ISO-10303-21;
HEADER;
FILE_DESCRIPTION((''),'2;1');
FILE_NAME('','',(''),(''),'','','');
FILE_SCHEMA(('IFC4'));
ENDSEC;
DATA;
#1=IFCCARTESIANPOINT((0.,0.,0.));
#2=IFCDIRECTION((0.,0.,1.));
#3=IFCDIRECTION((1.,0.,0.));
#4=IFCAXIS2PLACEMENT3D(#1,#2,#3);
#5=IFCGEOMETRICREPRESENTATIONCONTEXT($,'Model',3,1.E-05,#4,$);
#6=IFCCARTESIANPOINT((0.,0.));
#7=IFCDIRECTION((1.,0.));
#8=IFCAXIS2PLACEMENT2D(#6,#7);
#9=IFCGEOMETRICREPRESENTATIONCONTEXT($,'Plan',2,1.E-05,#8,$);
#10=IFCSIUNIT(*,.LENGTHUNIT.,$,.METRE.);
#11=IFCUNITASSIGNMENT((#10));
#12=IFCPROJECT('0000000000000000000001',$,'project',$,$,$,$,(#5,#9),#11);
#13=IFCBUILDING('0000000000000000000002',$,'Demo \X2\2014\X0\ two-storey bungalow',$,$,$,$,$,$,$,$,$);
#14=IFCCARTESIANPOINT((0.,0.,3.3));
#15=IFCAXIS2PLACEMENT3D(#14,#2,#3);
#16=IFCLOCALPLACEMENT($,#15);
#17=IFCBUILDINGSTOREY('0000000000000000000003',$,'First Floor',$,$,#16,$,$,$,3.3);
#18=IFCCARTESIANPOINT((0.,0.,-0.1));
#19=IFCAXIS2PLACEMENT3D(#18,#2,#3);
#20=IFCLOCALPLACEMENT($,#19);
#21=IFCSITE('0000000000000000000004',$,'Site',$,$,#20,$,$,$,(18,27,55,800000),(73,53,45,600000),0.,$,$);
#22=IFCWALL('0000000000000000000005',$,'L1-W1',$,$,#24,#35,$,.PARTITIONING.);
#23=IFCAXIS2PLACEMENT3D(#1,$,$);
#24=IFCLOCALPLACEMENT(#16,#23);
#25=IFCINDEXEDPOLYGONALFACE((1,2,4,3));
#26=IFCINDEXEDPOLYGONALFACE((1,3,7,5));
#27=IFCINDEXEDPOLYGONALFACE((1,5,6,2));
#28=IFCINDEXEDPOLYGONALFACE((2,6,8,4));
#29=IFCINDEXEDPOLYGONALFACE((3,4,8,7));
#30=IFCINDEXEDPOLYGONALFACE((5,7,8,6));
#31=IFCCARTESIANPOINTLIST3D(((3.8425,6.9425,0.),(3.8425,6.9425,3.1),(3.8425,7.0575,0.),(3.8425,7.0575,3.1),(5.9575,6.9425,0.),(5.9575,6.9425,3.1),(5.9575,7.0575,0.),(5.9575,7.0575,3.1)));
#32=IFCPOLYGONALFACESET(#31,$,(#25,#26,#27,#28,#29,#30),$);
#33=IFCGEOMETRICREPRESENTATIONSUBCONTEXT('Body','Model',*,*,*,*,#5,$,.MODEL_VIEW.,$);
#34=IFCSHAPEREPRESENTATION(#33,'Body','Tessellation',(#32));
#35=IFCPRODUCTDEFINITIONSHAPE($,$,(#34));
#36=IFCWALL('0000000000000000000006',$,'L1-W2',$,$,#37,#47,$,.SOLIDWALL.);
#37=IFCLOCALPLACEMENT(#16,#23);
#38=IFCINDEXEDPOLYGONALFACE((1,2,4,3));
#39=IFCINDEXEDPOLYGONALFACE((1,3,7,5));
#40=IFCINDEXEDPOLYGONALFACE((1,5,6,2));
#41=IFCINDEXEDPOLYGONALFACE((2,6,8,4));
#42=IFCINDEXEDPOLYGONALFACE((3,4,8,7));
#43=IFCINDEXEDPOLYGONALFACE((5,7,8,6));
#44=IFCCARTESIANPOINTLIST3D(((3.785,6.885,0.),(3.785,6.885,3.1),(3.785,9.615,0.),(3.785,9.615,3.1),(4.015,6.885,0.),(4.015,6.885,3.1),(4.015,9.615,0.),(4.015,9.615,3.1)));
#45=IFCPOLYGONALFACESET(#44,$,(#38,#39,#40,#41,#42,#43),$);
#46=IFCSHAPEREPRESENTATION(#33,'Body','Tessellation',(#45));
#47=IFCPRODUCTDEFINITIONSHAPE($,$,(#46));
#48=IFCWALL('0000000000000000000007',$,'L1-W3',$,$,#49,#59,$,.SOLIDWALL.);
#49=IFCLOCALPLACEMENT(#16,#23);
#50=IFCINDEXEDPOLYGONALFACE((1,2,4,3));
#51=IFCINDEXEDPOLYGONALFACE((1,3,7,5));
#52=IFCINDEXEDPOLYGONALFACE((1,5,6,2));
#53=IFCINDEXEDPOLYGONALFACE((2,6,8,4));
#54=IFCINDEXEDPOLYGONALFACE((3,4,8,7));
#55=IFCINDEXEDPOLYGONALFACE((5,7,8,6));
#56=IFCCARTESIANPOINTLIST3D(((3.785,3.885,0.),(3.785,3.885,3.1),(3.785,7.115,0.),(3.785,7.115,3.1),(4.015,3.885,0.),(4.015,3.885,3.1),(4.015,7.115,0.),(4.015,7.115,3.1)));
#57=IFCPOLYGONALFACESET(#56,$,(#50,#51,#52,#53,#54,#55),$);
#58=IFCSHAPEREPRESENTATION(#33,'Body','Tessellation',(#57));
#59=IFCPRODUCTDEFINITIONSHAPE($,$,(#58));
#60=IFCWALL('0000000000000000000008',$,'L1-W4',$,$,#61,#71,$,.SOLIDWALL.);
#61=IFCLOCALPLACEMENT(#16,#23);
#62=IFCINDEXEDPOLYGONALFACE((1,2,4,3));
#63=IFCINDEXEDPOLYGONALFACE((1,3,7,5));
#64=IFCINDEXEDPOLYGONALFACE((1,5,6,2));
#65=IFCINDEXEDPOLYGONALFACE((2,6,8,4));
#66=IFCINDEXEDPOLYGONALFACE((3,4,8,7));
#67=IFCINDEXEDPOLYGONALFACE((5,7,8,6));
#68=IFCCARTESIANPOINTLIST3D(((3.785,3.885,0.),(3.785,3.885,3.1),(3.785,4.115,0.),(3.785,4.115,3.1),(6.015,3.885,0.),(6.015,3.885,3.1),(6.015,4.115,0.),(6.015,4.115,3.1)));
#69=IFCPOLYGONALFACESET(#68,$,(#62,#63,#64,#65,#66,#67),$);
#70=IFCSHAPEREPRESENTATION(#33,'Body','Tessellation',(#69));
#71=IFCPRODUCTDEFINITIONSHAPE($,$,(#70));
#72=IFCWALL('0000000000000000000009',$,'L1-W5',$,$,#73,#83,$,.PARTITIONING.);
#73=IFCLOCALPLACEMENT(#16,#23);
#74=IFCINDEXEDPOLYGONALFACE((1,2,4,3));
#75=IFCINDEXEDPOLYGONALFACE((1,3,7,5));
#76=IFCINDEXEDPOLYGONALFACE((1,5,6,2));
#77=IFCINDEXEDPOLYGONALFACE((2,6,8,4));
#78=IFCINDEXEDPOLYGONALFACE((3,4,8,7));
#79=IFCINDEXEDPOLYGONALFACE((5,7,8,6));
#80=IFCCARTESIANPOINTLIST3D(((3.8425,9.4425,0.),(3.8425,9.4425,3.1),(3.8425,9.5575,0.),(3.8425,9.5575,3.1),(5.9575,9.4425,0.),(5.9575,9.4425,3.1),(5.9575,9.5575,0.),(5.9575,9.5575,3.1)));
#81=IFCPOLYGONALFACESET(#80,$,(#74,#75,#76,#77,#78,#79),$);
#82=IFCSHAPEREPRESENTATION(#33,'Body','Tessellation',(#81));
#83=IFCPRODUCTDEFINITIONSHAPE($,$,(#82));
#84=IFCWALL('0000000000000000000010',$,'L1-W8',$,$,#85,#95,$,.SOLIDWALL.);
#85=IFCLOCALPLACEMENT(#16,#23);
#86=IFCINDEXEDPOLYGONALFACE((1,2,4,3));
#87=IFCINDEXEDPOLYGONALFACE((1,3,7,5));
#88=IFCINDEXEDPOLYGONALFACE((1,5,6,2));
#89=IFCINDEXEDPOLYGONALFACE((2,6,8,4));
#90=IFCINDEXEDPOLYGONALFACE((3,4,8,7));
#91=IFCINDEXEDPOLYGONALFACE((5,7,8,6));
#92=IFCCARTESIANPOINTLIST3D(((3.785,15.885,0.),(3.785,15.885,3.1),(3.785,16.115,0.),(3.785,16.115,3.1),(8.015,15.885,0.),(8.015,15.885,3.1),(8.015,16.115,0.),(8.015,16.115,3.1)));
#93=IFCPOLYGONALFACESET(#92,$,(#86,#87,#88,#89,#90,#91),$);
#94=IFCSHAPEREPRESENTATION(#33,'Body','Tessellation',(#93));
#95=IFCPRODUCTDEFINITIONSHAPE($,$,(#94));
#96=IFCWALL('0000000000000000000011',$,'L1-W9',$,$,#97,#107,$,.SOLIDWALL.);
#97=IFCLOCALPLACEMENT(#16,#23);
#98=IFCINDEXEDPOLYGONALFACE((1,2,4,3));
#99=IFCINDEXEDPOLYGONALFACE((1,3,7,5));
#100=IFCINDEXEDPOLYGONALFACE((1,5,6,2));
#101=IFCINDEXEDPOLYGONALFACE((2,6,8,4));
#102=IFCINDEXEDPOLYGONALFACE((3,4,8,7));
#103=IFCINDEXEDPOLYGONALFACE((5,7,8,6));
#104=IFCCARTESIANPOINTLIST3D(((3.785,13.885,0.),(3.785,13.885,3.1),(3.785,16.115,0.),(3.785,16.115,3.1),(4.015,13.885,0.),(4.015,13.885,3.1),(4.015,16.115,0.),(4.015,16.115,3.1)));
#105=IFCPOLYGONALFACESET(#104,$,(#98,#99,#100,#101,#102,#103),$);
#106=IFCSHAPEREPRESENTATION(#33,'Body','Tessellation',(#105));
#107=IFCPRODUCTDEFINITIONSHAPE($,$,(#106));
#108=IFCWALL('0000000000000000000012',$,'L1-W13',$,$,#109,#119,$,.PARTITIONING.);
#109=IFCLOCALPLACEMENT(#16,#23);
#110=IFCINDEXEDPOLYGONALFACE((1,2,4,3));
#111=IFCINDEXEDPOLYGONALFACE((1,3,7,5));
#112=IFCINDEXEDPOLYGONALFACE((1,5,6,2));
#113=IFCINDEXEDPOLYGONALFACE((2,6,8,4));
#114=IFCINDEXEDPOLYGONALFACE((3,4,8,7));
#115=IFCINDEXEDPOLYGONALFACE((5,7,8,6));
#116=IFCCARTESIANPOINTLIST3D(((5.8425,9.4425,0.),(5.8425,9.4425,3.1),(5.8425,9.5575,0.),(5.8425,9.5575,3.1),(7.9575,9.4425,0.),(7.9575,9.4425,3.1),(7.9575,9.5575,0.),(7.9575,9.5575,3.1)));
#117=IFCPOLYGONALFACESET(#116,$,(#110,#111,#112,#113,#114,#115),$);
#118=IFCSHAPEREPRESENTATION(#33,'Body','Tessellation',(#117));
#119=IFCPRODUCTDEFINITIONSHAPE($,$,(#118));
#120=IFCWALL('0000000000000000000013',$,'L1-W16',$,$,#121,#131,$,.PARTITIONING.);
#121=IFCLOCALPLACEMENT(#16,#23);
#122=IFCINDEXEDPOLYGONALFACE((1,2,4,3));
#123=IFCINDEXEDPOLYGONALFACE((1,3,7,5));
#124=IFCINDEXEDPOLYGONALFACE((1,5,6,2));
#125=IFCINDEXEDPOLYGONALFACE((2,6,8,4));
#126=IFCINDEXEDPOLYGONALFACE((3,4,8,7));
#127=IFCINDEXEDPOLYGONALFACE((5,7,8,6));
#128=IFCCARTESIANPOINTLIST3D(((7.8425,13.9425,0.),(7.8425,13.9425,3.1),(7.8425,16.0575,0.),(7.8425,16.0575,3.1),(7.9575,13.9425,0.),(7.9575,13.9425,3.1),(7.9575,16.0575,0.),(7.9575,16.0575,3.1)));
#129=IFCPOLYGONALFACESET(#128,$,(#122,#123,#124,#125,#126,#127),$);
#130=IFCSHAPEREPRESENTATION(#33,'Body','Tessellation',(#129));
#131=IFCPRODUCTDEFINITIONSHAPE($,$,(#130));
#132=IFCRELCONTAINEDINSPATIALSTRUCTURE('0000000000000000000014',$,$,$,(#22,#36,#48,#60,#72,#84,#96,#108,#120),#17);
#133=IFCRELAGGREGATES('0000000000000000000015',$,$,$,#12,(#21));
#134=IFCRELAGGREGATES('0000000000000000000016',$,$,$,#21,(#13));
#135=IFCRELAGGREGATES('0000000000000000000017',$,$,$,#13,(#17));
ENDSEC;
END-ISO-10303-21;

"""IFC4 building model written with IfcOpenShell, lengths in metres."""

from ifc_helpers import new_model, si_unit, frame, origin_with_axes, origin_2d_with_axis, place, context, subcontext, project, spatial, line, indexed_curve, outline, extrude, element, save


model = new_model("IFC4")

# Units and contexts
model_context = context("Model", 3, precision=1e-05, world=origin_with_axes())
plan_context = context("Plan", 2, precision=1e-05, world=origin_2d_with_axis())
body_context = subcontext(model_context, "Body", "Model", "MODEL_VIEW")
ifc_project = project(units=[si_unit("LENGTHUNIT", "METRE")], contexts=[model_context, plan_context])

# Site, building, storey
site_placement = place(None, frame((0.0, 0.0, -0.1), z_axis=(0.0, 0.0, 1.0), x_axis=(1.0, 0.0, 0.0)))
site = spatial("IfcSite", under=ifc_project, at=site_placement, Name="Site", RefLatitude=(18, 27, 55, 800000), RefLongitude=(73, 53, 45, 600000), RefElevation=0.0)
building = spatial("IfcBuilding", under=site, Name="Demo — two-storey bungalow")
storey_placement = place(None, frame((0.0, 0.0, 3.3), z_axis=(0.0, 0.0, 1.0), x_axis=(1.0, 0.0, 0.0)))
storey = spatial("IfcBuildingStorey", under=building, at=storey_placement, Name="First Floor", Elevation=3.3)

# Walls
wall_1_placement = place(storey_placement, frame((0.0, 0.0, -3.3), z_axis=(0.0, 0.0, 1.0), x_axis=(1.0, 0.0, 0.0)))
element("IfcWall", 1, at=wall_1_placement, inside=storey, Name="L1-W1", PredefinedType="PARTITIONING", context=body_context, shape_type="SweptSolid", body=[
    extrude(outline(indexed_curve([(5.9575, 6.9425), (3.8425, 6.9425), (3.8425, 7.0575), (5.9575, 7.0575)], segments=[line(1, 2, 3, 4, 1)])), frame((0.0, 0.0, 3.3), z_axis=(0.0, 0.0, 1.0), x_axis=(1.0, 0.0, 0.0)), (0.0, 0.0, 1.0), 3.1),
])
wall_2_placement = place(storey_placement, frame((0.0, 0.0, -3.3), z_axis=(0.0, 0.0, 1.0), x_axis=(1.0, 0.0, 0.0)))
element("IfcWall", 2, at=wall_2_placement, inside=storey, Name="L1-W2", PredefinedType="SOLIDWALL", context=body_context, shape_type="SweptSolid", body=[
    extrude(outline(indexed_curve([(4.015, 9.615), (4.015, 6.885), (3.785, 6.885), (3.785, 9.615)], segments=[line(1, 2, 3, 4, 1)])), frame((0.0, 0.0, 3.3), z_axis=(0.0, 0.0, 1.0), x_axis=(1.0, 0.0, 0.0)), (0.0, 0.0, 1.0), 3.1),
])
wall_3_placement = place(storey_placement, frame((0.0, 0.0, -3.3), z_axis=(0.0, 0.0, 1.0), x_axis=(1.0, 0.0, 0.0)))
element("IfcWall", 3, at=wall_3_placement, inside=storey, Name="L1-W3", PredefinedType="SOLIDWALL", context=body_context, shape_type="SweptSolid", body=[
    extrude(outline(indexed_curve([(4.015, 7.115), (4.015, 3.885), (3.785, 3.885), (3.785, 7.115)], segments=[line(1, 2, 3, 4, 1)])), frame((0.0, 0.0, 3.3), z_axis=(0.0, 0.0, 1.0), x_axis=(1.0, 0.0, 0.0)), (0.0, 0.0, 1.0), 3.1),
])
wall_4_placement = place(storey_placement, frame((0.0, 0.0, -3.3), z_axis=(0.0, 0.0, 1.0), x_axis=(1.0, 0.0, 0.0)))
element("IfcWall", 4, at=wall_4_placement, inside=storey, Name="L1-W4", PredefinedType="SOLIDWALL", context=body_context, shape_type="SweptSolid", body=[
    extrude(outline(indexed_curve([(3.785, 4.115), (6.015, 4.115), (6.015, 3.885), (3.785, 3.885)], segments=[line(1, 2, 3, 4, 1)])), frame((0.0, 0.0, 3.3), z_axis=(0.0, 0.0, 1.0), x_axis=(1.0, 0.0, 0.0)), (0.0, 0.0, 1.0), 3.1),
])
wall_5_placement = place(storey_placement, frame((0.0, 0.0, -3.3), z_axis=(0.0, 0.0, 1.0), x_axis=(1.0, 0.0, 0.0)))
element("IfcWall", 5, at=wall_5_placement, inside=storey, Name="L1-W5", PredefinedType="PARTITIONING", context=body_context, shape_type="SweptSolid", body=[
    extrude(outline(indexed_curve([(5.9575, 9.4425), (3.8425, 9.4425), (3.8425, 9.5575), (5.9575, 9.5575)], segments=[line(1, 2, 3, 4, 1)])), frame((0.0, 0.0, 3.3), z_axis=(0.0, 0.0, 1.0), x_axis=(1.0, 0.0, 0.0)), (0.0, 0.0, 1.0), 3.1),
])

# Walls
wall_6_placement = place(storey_placement, frame((0.0, 0.0, -3.3), z_axis=(0.0, 0.0, 1.0), x_axis=(1.0, 0.0, 0.0)))
element("IfcWall", 6, at=wall_6_placement, inside=storey, Name="L1-W8", PredefinedType="SOLIDWALL", context=body_context, shape_type="SweptSolid", body=[
    extrude(outline(indexed_curve([(8.015, 15.885), (3.785, 15.885), (3.785, 16.115), (8.015, 16.115)], segments=[line(1, 2, 3, 4, 1)])), frame((0.0, 0.0, 3.3), z_axis=(0.0, 0.0, 1.0), x_axis=(1.0, 0.0, 0.0)), (0.0, 0.0, 1.0), 3.1),
])
wall_7_placement = place(storey_placement, frame((0.0, 0.0, -3.3), z_axis=(0.0, 0.0, 1.0), x_axis=(1.0, 0.0, 0.0)))
element("IfcWall", 7, at=wall_7_placement, inside=storey, Name="L1-W9", PredefinedType="SOLIDWALL", context=body_context, shape_type="SweptSolid", body=[
    extrude(outline(indexed_curve([(4.015, 16.115), (4.015, 13.885), (3.785, 13.885), (3.785, 16.115)], segments=[line(1, 2, 3, 4, 1)])), frame((0.0, 0.0, 3.3), z_axis=(0.0, 0.0, 1.0), x_axis=(1.0, 0.0, 0.0)), (0.0, 0.0, 1.0), 3.1),
])

# Wall
wall_8_placement = place(storey_placement, frame((0.0, 0.0, -3.3), z_axis=(0.0, 0.0, 1.0), x_axis=(1.0, 0.0, 0.0)))
element("IfcWall", 8, at=wall_8_placement, inside=storey, Name="L1-W13", PredefinedType="PARTITIONING", context=body_context, shape_type="SweptSolid", body=[
    extrude(outline(indexed_curve([(7.9575, 9.4425), (5.8425, 9.4425), (5.8425, 9.5575), (7.9575, 9.5575)], segments=[line(1, 2, 3, 4, 1)])), frame((0.0, 0.0, 3.3), z_axis=(0.0, 0.0, 1.0), x_axis=(1.0, 0.0, 0.0)), (0.0, 0.0, 1.0), 3.1),
])

# Wall
wall_9_placement = place(storey_placement, frame((0.0, 0.0, -3.3), z_axis=(0.0, 0.0, 1.0), x_axis=(1.0, 0.0, 0.0)))
element("IfcWall", 9, at=wall_9_placement, inside=storey, Name="L1-W16", PredefinedType="PARTITIONING", context=body_context, shape_type="SweptSolid", body=[
    extrude(outline(indexed_curve([(7.8425, 13.9425), (7.8425, 16.0575), (7.9575, 16.0575), (7.9575, 13.9425)], segments=[line(1, 2, 3, 4, 1)])), frame((0.0, 0.0, 3.3), z_axis=(0.0, 0.0, 1.0), x_axis=(1.0, 0.0, 0.0)), (0.0, 0.0, 1.0), 3.1),
])

save(model, "model.ifc")
